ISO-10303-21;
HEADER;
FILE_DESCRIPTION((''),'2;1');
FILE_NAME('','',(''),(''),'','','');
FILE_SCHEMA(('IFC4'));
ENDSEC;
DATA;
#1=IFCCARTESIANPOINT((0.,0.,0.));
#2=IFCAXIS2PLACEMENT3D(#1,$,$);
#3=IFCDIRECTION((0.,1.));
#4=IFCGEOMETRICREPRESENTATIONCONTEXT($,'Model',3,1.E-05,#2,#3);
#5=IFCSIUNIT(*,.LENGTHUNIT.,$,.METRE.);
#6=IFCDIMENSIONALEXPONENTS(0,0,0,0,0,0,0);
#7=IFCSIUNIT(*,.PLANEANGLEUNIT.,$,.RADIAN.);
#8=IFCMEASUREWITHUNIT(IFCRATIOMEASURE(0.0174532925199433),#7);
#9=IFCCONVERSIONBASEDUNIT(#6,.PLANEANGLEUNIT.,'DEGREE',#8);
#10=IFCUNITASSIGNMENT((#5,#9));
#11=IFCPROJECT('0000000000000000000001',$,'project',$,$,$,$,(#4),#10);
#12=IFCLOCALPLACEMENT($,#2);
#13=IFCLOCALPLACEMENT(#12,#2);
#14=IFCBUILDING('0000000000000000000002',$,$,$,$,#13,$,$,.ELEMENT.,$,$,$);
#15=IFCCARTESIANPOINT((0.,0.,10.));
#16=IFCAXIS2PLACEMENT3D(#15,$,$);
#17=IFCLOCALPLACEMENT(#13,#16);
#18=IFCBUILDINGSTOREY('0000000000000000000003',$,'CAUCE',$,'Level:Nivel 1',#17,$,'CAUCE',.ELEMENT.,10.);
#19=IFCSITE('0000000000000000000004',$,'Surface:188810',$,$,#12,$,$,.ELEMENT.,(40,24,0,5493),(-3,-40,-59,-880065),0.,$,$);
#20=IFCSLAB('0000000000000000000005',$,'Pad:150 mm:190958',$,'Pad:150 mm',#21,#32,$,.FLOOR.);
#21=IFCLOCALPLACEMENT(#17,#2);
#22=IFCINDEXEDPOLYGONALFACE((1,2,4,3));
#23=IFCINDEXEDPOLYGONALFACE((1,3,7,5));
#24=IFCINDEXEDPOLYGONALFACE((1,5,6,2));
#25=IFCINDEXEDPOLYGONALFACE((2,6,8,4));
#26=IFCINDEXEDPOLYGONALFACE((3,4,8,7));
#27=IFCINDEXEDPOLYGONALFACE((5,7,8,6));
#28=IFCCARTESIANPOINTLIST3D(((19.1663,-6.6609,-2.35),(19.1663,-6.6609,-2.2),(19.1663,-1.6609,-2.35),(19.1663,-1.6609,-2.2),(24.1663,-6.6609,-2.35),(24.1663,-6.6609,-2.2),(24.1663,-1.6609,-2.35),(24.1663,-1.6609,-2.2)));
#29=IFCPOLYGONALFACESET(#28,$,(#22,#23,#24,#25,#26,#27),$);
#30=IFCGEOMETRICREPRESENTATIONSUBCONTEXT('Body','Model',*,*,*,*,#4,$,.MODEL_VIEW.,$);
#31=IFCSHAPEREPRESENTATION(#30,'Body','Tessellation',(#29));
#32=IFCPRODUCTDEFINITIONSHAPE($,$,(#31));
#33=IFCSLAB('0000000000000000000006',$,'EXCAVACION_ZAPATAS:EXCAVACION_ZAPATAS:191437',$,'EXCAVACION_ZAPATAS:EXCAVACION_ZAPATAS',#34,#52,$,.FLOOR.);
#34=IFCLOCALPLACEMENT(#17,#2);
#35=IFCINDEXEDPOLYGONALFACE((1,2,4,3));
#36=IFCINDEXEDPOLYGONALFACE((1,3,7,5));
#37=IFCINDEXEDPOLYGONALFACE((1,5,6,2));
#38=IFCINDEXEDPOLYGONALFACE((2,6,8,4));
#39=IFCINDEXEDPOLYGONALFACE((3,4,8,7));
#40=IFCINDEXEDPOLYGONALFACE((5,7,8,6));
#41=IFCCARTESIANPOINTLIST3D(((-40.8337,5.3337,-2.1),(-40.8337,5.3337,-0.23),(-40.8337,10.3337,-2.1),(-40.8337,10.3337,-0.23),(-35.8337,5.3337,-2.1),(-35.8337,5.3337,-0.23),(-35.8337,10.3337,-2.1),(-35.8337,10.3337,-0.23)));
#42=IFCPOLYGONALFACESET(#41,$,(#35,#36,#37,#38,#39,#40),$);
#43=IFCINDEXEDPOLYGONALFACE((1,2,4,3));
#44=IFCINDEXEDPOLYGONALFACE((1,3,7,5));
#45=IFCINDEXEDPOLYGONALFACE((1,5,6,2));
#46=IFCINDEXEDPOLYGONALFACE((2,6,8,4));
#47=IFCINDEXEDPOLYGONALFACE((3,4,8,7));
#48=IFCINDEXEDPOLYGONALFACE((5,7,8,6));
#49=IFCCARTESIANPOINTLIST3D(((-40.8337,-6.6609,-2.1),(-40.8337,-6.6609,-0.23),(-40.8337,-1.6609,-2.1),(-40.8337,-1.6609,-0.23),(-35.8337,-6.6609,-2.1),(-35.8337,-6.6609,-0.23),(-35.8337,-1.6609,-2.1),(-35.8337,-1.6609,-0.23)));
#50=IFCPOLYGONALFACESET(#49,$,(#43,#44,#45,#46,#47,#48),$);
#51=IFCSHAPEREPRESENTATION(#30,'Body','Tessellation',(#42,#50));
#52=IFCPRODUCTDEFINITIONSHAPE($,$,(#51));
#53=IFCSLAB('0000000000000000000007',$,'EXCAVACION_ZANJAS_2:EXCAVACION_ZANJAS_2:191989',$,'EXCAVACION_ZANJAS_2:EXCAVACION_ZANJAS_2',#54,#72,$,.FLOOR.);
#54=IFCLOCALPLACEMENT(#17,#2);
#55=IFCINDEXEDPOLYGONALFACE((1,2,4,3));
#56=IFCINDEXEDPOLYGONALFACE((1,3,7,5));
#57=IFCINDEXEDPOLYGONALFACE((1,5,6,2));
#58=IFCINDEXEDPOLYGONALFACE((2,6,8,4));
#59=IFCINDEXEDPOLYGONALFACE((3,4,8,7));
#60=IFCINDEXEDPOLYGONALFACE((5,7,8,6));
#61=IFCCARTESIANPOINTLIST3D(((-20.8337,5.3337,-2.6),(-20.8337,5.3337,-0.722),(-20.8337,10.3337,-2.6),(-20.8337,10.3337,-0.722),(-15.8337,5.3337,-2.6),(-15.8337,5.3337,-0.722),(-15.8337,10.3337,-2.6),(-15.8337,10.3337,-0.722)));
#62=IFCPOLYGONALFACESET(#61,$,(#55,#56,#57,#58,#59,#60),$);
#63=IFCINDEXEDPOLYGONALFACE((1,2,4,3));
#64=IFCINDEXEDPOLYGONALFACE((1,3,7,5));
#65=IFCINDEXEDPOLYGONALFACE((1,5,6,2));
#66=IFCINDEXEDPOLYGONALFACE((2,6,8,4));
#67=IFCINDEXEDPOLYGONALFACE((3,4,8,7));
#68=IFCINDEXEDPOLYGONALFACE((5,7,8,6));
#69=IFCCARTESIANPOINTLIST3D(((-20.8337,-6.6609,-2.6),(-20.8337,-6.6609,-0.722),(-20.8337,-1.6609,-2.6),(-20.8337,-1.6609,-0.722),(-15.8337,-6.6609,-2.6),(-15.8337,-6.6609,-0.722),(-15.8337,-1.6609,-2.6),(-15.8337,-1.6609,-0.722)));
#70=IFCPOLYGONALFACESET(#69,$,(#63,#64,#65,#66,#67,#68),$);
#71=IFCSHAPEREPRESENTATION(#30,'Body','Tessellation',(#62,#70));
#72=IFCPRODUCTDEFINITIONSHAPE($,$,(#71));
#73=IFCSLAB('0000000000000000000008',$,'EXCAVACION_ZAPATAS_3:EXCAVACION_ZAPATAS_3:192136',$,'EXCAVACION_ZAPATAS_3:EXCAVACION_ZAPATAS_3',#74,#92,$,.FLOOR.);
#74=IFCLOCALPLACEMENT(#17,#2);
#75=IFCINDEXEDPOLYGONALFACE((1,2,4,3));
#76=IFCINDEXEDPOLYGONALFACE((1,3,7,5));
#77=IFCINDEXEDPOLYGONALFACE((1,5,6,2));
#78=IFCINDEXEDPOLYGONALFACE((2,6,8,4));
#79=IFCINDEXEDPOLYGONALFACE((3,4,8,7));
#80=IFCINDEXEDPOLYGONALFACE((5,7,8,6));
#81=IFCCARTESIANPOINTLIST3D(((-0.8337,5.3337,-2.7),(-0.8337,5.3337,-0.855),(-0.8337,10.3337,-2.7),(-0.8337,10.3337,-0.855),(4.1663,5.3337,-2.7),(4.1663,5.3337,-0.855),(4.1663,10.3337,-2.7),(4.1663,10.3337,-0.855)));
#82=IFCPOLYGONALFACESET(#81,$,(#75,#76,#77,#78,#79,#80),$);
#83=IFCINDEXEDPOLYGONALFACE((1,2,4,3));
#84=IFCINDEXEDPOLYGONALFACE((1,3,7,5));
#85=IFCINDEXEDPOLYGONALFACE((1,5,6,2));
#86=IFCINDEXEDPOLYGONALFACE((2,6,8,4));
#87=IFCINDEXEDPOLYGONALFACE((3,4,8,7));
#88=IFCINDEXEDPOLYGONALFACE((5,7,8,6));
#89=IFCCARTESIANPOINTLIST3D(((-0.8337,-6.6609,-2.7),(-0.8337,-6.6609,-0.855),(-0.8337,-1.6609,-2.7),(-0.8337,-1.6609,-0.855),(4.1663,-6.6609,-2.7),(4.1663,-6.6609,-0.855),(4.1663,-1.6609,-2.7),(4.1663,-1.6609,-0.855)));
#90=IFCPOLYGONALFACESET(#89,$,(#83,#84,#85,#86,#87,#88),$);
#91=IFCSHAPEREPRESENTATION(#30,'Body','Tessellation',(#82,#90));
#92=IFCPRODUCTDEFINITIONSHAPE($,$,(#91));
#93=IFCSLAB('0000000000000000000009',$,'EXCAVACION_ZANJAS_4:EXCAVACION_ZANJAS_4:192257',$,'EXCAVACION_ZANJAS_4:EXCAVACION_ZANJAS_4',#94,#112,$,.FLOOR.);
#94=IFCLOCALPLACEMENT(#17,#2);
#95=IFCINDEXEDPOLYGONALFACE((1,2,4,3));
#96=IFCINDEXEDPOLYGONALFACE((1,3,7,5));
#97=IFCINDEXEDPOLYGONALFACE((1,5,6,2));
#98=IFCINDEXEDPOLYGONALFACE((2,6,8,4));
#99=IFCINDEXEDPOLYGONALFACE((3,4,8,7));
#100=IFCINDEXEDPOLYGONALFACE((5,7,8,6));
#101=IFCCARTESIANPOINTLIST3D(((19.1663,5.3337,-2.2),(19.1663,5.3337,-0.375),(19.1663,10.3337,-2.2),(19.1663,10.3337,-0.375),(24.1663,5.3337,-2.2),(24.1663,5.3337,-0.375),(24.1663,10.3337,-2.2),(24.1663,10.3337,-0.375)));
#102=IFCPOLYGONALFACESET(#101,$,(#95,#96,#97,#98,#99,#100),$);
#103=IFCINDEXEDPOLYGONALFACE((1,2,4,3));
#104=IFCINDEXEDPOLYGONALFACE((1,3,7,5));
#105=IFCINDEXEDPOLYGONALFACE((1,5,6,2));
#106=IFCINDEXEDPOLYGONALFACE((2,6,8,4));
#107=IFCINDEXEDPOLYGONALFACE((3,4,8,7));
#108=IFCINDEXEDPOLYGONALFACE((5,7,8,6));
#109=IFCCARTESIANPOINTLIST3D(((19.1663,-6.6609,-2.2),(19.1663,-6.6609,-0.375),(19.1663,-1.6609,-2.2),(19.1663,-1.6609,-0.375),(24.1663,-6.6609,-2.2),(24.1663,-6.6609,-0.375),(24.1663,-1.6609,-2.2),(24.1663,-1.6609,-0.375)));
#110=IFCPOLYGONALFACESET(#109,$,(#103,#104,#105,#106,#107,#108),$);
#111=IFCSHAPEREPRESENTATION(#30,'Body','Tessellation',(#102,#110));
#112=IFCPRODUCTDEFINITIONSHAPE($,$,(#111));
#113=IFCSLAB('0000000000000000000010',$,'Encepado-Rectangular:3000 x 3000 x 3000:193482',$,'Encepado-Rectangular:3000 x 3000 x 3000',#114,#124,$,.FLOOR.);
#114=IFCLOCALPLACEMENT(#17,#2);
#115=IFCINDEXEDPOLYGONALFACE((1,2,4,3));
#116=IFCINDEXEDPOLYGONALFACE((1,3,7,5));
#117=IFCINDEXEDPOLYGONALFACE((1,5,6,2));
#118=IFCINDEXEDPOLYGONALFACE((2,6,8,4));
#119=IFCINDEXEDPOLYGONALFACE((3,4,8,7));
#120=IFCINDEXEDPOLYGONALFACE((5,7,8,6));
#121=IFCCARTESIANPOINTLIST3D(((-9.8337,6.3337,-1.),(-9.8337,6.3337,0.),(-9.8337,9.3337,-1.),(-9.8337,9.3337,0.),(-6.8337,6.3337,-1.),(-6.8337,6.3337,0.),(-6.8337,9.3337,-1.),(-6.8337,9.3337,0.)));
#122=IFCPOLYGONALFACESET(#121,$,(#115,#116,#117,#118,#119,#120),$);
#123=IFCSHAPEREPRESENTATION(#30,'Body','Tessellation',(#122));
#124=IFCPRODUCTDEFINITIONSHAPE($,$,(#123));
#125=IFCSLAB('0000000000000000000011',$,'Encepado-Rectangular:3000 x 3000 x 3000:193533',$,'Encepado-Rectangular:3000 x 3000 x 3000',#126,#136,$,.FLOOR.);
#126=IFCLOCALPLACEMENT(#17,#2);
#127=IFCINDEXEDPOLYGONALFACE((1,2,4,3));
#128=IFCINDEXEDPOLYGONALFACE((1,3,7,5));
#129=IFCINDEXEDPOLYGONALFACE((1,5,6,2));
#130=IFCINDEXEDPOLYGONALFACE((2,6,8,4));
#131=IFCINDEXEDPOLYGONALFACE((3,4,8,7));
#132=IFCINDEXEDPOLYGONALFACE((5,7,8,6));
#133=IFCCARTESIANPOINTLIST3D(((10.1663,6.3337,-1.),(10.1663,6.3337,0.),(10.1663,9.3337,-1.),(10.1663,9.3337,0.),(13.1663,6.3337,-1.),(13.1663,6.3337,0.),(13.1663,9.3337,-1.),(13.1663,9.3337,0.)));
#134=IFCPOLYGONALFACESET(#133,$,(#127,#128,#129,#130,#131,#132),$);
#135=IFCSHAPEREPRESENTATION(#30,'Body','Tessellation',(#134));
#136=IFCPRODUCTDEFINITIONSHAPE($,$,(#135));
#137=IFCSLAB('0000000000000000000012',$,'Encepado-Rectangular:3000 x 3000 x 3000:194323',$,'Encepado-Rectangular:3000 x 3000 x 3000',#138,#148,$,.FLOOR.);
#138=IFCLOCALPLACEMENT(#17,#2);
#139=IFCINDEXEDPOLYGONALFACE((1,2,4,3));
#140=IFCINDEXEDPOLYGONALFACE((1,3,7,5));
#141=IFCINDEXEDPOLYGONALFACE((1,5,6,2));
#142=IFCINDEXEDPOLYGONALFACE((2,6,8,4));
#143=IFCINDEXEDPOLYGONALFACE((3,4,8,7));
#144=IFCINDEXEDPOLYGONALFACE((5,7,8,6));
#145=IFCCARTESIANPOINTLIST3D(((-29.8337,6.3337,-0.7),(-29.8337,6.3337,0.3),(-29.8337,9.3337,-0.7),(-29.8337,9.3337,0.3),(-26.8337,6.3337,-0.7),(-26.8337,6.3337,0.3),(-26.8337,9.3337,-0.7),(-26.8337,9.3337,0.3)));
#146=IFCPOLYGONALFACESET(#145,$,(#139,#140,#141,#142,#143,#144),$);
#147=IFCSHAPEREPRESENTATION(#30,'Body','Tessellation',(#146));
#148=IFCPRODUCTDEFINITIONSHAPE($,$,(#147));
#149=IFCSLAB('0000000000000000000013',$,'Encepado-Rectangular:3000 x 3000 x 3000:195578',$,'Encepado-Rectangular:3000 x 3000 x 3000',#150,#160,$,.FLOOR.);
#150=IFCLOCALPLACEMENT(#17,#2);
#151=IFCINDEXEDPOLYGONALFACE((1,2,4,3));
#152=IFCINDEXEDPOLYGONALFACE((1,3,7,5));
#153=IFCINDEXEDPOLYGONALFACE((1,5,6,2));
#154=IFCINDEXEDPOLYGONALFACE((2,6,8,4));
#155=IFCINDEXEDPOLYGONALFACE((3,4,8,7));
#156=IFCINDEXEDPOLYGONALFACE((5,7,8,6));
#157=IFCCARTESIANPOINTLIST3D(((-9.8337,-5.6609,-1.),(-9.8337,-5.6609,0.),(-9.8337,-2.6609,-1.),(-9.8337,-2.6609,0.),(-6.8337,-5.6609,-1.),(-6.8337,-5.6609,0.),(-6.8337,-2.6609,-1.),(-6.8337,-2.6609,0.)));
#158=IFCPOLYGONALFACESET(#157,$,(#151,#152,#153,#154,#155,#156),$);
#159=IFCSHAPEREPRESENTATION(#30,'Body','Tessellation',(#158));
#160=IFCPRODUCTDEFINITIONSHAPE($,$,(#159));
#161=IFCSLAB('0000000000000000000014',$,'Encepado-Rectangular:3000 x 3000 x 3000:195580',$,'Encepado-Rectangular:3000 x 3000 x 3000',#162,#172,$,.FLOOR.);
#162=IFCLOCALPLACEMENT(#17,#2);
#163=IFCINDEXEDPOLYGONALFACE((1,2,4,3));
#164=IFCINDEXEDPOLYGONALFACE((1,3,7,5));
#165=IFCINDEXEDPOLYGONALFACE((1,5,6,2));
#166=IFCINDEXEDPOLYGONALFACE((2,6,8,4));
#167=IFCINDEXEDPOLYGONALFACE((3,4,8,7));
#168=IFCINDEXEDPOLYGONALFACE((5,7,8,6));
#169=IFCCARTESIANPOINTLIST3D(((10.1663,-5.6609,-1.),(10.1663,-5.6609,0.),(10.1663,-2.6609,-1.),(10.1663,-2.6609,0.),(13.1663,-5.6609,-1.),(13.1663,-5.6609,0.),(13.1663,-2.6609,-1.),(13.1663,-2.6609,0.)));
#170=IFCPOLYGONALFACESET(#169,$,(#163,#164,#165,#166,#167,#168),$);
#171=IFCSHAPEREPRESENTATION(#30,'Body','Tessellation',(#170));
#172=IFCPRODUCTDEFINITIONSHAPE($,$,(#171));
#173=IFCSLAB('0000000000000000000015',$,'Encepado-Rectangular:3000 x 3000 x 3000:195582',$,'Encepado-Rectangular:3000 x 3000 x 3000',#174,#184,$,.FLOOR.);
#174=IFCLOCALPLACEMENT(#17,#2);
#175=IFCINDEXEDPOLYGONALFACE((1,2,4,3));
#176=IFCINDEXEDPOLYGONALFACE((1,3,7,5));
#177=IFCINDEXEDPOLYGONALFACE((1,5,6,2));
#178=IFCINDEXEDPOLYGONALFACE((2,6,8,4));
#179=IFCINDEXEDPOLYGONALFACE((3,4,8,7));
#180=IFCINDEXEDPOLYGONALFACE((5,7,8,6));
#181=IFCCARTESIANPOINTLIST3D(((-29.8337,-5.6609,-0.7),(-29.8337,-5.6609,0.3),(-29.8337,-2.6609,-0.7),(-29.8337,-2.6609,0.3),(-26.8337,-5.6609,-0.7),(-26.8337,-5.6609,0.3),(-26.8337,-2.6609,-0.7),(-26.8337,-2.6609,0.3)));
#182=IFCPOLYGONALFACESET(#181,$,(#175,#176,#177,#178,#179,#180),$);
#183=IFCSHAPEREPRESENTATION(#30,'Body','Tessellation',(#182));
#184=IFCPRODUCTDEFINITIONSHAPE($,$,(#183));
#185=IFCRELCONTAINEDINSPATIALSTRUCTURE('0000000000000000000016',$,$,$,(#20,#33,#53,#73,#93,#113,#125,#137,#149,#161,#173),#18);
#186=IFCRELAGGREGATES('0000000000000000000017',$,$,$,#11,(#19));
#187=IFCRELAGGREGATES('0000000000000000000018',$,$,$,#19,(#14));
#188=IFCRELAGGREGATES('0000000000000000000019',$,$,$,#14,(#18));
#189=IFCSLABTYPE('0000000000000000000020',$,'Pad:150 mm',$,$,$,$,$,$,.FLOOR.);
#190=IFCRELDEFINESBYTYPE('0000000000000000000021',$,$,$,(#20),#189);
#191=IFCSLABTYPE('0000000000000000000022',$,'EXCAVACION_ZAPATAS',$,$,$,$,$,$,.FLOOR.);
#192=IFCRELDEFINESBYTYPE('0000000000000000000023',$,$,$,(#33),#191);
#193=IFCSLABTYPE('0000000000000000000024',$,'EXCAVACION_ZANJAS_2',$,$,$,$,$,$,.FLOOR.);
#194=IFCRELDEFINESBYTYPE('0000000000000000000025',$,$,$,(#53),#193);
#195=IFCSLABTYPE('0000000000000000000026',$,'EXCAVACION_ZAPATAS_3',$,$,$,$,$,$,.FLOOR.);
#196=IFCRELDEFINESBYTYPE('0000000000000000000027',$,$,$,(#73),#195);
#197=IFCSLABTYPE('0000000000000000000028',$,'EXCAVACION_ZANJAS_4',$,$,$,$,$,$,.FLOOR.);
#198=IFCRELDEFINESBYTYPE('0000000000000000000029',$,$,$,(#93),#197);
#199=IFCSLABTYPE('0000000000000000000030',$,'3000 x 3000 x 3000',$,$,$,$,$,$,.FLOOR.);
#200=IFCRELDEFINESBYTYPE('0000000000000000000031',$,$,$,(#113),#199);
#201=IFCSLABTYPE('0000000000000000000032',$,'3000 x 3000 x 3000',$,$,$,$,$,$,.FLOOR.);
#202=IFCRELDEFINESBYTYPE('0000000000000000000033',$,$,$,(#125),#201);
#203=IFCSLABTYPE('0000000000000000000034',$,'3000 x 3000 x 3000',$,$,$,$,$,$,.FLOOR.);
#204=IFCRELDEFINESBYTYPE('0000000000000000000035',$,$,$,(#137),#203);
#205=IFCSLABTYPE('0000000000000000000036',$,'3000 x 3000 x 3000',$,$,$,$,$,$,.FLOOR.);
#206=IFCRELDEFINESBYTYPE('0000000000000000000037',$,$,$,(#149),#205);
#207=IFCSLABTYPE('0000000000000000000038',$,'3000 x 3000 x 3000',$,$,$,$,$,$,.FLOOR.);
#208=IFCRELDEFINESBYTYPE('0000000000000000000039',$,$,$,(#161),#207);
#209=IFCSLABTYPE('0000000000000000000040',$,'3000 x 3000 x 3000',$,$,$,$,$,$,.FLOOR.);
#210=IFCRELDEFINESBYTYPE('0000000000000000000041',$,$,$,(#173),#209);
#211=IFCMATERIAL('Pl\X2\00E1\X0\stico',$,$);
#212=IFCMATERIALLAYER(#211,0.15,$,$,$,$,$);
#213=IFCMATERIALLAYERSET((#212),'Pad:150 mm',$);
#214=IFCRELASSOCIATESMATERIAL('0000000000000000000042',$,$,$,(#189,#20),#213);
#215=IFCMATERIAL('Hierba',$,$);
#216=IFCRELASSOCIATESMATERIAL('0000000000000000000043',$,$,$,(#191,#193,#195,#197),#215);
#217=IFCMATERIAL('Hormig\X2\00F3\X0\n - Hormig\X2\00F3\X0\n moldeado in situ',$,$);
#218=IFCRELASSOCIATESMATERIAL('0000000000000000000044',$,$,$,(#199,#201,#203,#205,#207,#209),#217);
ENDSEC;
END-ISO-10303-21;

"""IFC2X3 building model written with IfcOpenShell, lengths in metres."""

from ifc_helpers import new_model, entity, si_unit, converted_unit, direction, frame, frame_2d, origin, origin_2d_with_axis, place, context, subcontext, project, spatial, rectangle, extrude, material, layer, layer_set, layer_usage, type_object, element, save


model = new_model("IFC2X3")

# Units and contexts
model_context = context("Model", 3, precision=1e-05, world=origin(), true_north=direction((0.0, 1.0)))
body_context = subcontext(model_context, "Body", "Model", "MODEL_VIEW")
ifc_project = project(units=[si_unit("LENGTHUNIT", "METRE"), converted_unit("PLANEANGLEUNIT", "DEGREE", entity("IfcRatioMeasure", 0.0174532925199433), si_unit("PLANEANGLEUNIT", "RADIAN"), dimensions=[0, 0, 0, 0, 0, 0, 0])], contexts=[model_context])

# Site, building, storey
site_placement = place(None, origin())
site = spatial("IfcSite", under=ifc_project, at=site_placement, Name="Surface:188810", CompositionType="ELEMENT", RefLatitude=(40, 24, 0, 5493), RefLongitude=(-3, -40, -59, -880065), RefElevation=0.0)
building_placement = place(site_placement, origin())
building = spatial("IfcBuilding", under=site, at=building_placement, CompositionType="ELEMENT")
storey_placement = place(building_placement, frame((0.0, 0.0, 10.0)))
storey = spatial("IfcBuildingStorey", under=building, at=storey_placement, Name="CAUCE", ObjectType="Level:Nivel 1", LongName="CAUCE", CompositionType="ELEMENT", Elevation=10.0)

# Shared definitions
ifc_material_1 = material(Name="Hormigón - Hormigón moldeado in situ")

# Slabs
ifc_material_2 = material(Name="Plástico")
ifc_layer_1 = layer(ifc_material_2, 0.15)
ifc_layer_set_1 = layer_set([ifc_layer_1], Name="Pad:150 mm")
ifc_layer_usage_1 = layer_usage(ifc_layer_set_1, "AXIS3", "POSITIVE", 0.0)
slab_type_1 = type_object("IfcSlabType", Name="Pad:150 mm", PredefinedType="FLOOR", material=ifc_layer_set_1)
slab_1_placement = place(storey_placement, origin())
element("IfcSlab", 1, at=slab_1_placement, inside=storey, type_object=slab_type_1, material=ifc_layer_usage_1, Name="Pad:150 mm:190958", ObjectType="Pad:150 mm", PredefinedType="FLOOR", context=body_context, shape_type="SweptSolid", body=[
    extrude(rectangle(XDim=5.0, YDim=5.0, at=origin_2d_with_axis()), frame((21.6663, -4.1609, -2.35), z_axis=(0.0, 0.0, 1.0), x_axis=(0.0, 1.0, 0.0)), (0.0, 0.0, 1.0), 0.15),
])
ifc_material_3 = material(Name="Hierba")
slab_type_2 = type_object("IfcSlabType", Name="EXCAVACION_ZAPATAS", PredefinedType="FLOOR", material=ifc_material_3)
slab_2_placement = place(storey_placement, origin())
element("IfcSlab", 2, at=slab_2_placement, inside=storey, type_object=slab_type_2, Name="EXCAVACION_ZAPATAS:EXCAVACION_ZAPATAS:191437", ObjectType="EXCAVACION_ZAPATAS:EXCAVACION_ZAPATAS", PredefinedType="FLOOR", context=body_context, shape_type="SweptSolid", body=[
    extrude(rectangle(XDim=5.0, YDim=5.0, at=frame_2d((0.0, 0.0), x_axis=(1.0, 0.0))), frame((-38.3337, 7.8337, -2.1), z_axis=(0.0, 0.0, 1.0), x_axis=(-1.0, 0.0, 0.0)), (0.0, 0.0, 1.0), 1.87),
    extrude(rectangle(XDim=5.0, YDim=5.0, at=frame_2d((0.0, 0.0), x_axis=(1.0, 0.0))), frame((-38.3337, -4.1609, -2.1), z_axis=(0.0, 0.0, 1.0), x_axis=(0.0, 1.0, 0.0)), (0.0, 0.0, 1.0), 1.87),
])
slab_type_3 = type_object("IfcSlabType", Name="EXCAVACION_ZANJAS_2", PredefinedType="FLOOR", material=ifc_material_3)
slab_3_placement = place(storey_placement, origin())
element("IfcSlab", 3, at=slab_3_placement, inside=storey, type_object=slab_type_3, Name="EXCAVACION_ZANJAS_2:EXCAVACION_ZANJAS_2:191989", ObjectType="EXCAVACION_ZANJAS_2:EXCAVACION_ZANJAS_2", PredefinedType="FLOOR", context=body_context, shape_type="SweptSolid", body=[
    extrude(rectangle(XDim=5.0, YDim=5.0, at=origin_2d_with_axis()), frame((-18.3337, 7.8337, -2.6), z_axis=(0.0, 0.0, 1.0), x_axis=(-1.0, 0.0, 0.0)), (0.0, 0.0, 1.0), 1.878),
    extrude(rectangle(XDim=5.0, YDim=5.0, at=frame_2d((0.0, 0.0), x_axis=(1.0, 0.0))), frame((-18.3337, -4.1609, -2.6), z_axis=(0.0, 0.0, 1.0), x_axis=(-1.0, 0.0, 0.0)), (0.0, 0.0, 1.0), 1.878),
])
slab_type_4 = type_object("IfcSlabType", Name="EXCAVACION_ZAPATAS_3", PredefinedType="FLOOR", material=ifc_material_3)
slab_4_placement = place(storey_placement, origin())
element("IfcSlab", 4, at=slab_4_placement, inside=storey, type_object=slab_type_4, Name="EXCAVACION_ZAPATAS_3:EXCAVACION_ZAPATAS_3:192136", ObjectType="EXCAVACION_ZAPATAS_3:EXCAVACION_ZAPATAS_3", PredefinedType="FLOOR", context=body_context, shape_type="SweptSolid", body=[
    extrude(rectangle(XDim=5.0, YDim=5.0, at=origin_2d_with_axis()), frame((1.6663, 7.8337, -2.7), z_axis=(0.0, 0.0, 1.0), x_axis=(-1.0, 0.0, 0.0)), (0.0, 0.0, 1.0), 1.845),
    extrude(rectangle(XDim=5.0, YDim=5.0, at=origin_2d_with_axis()), frame((1.6663, -4.1609, -2.7), z_axis=(0.0, 0.0, 1.0), x_axis=(-1.0, 0.0, 0.0)), (0.0, 0.0, 1.0), 1.845),
])
slab_type_5 = type_object("IfcSlabType", Name="EXCAVACION_ZANJAS_4", PredefinedType="FLOOR", material=ifc_material_3)
slab_5_placement = place(storey_placement, origin())
element("IfcSlab", 5, at=slab_5_placement, inside=storey, type_object=slab_type_5, Name="EXCAVACION_ZANJAS_4:EXCAVACION_ZANJAS_4:192257", ObjectType="EXCAVACION_ZANJAS_4:EXCAVACION_ZANJAS_4", PredefinedType="FLOOR", context=body_context, shape_type="SweptSolid", body=[
    extrude(rectangle(XDim=5.0, YDim=5.0, at=origin_2d_with_axis()), frame((21.6663, 7.8337, -2.2), z_axis=(0.0, 0.0, 1.0), x_axis=(-1.0, 0.0, 0.0)), (0.0, 0.0, 1.0), 1.825),
    extrude(rectangle(XDim=5.0, YDim=5.0, at=origin_2d_with_axis()), frame((21.6663, -4.1609, -2.2), z_axis=(0.0, 0.0, 1.0), x_axis=(-1.0, 0.0, 0.0)), (0.0, 0.0, 1.0), 1.825),
])
slab_type_6 = type_object("IfcSlabType", Name="3000 x 3000 x 3000", PredefinedType="FLOOR", material=ifc_material_1)
slab_6_placement = place(storey_placement, origin())
element("IfcSlab", 6, at=slab_6_placement, inside=storey, type_object=slab_type_6, Name="Encepado-Rectangular:3000 x 3000 x 3000:193482", ObjectType="Encepado-Rectangular:3000 x 3000 x 3000", PredefinedType="FLOOR", context=body_context, shape_type="SweptSolid", body=[
    extrude(rectangle(XDim=3.0, YDim=3.0, at=frame_2d((0.0, 0.0), x_axis=(1.0, 0.0))), frame((-8.3337, 7.8337, -1.0), z_axis=(0.0, 0.0, 1.0), x_axis=(-1.0, 0.0, 0.0)), (0.0, 0.0, 1.0), 1.0),
])
slab_type_7 = type_object("IfcSlabType", Name="3000 x 3000 x 3000", PredefinedType="FLOOR", material=ifc_material_1)
slab_7_placement = place(storey_placement, origin())
element("IfcSlab", 7, at=slab_7_placement, inside=storey, type_object=slab_type_7, Name="Encepado-Rectangular:3000 x 3000 x 3000:193533", ObjectType="Encepado-Rectangular:3000 x 3000 x 3000", PredefinedType="FLOOR", context=body_context, shape_type="SweptSolid", body=[
    extrude(rectangle(XDim=3.0, YDim=3.0, at=frame_2d((0.0, 0.0), x_axis=(1.0, 0.0))), frame((11.6663, 7.8337, -1.0), z_axis=(0.0, 0.0, 1.0), x_axis=(-1.0, 0.0, 0.0)), (0.0, 0.0, 1.0), 1.0),
])
slab_type_8 = type_object("IfcSlabType", Name="3000 x 3000 x 3000", PredefinedType="FLOOR", material=ifc_material_1)
slab_8_placement = place(storey_placement, origin())
element("IfcSlab", 8, at=slab_8_placement, inside=storey, type_object=slab_type_8, Name="Encepado-Rectangular:3000 x 3000 x 3000:194323", ObjectType="Encepado-Rectangular:3000 x 3000 x 3000", PredefinedType="FLOOR", context=body_context, shape_type="SweptSolid", body=[
    extrude(rectangle(XDim=3.0, YDim=3.0, at=frame_2d((0.0, 0.0), x_axis=(1.0, 0.0))), frame((-28.3337, 7.8337, -0.7), z_axis=(0.0, 0.0, 1.0), x_axis=(-1.0, 0.0, 0.0)), (0.0, 0.0, 1.0), 1.0),
])
slab_type_9 = type_object("IfcSlabType", Name="3000 x 3000 x 3000", PredefinedType="FLOOR", material=ifc_material_1)
slab_9_placement = place(storey_placement, origin())
element("IfcSlab", 9, at=slab_9_placement, inside=storey, type_object=slab_type_9, Name="Encepado-Rectangular:3000 x 3000 x 3000:195578", ObjectType="Encepado-Rectangular:3000 x 3000 x 3000", PredefinedType="FLOOR", context=body_context, shape_type="SweptSolid", body=[
    extrude(rectangle(XDim=3.0, YDim=3.0, at=frame_2d((0.0, 0.0), x_axis=(1.0, 0.0))), frame((-8.3337, -4.1609, -1.0), z_axis=(0.0, 0.0, 1.0), x_axis=(0.0, 1.0, 0.0)), (0.0, 0.0, 1.0), 1.0),
])
slab_type_10 = type_object("IfcSlabType", Name="3000 x 3000 x 3000", PredefinedType="FLOOR", material=ifc_material_1)
slab_10_placement = place(storey_placement, origin())
element("IfcSlab", 10, at=slab_10_placement, inside=storey, type_object=slab_type_10, Name="Encepado-Rectangular:3000 x 3000 x 3000:195580", ObjectType="Encepado-Rectangular:3000 x 3000 x 3000", PredefinedType="FLOOR", context=body_context, shape_type="SweptSolid", body=[
    extrude(rectangle(XDim=3.0, YDim=3.0, at=frame_2d((0.0, 0.0), x_axis=(1.0, 0.0))), frame((11.6663, -4.1609, -1.0), z_axis=(0.0, 0.0, 1.0), x_axis=(0.0, 1.0, 0.0)), (0.0, 0.0, 1.0), 1.0),
])
slab_type_11 = type_object("IfcSlabType", Name="3000 x 3000 x 3000", PredefinedType="FLOOR", material=ifc_material_1)
slab_11_placement = place(storey_placement, origin())
element("IfcSlab", 11, at=slab_11_placement, inside=storey, type_object=slab_type_11, Name="Encepado-Rectangular:3000 x 3000 x 3000:195582", ObjectType="Encepado-Rectangular:3000 x 3000 x 3000", PredefinedType="FLOOR", context=body_context, shape_type="SweptSolid", body=[
    extrude(rectangle(XDim=3.0, YDim=3.0, at=frame_2d((0.0, 0.0), x_axis=(1.0, 0.0))), frame((-28.3337, -4.1609, -0.7), z_axis=(0.0, 0.0, 1.0), x_axis=(0.0, 1.0, 0.0)), (0.0, 0.0, 1.0), 1.0),
])

save(model, "model.ifc")
